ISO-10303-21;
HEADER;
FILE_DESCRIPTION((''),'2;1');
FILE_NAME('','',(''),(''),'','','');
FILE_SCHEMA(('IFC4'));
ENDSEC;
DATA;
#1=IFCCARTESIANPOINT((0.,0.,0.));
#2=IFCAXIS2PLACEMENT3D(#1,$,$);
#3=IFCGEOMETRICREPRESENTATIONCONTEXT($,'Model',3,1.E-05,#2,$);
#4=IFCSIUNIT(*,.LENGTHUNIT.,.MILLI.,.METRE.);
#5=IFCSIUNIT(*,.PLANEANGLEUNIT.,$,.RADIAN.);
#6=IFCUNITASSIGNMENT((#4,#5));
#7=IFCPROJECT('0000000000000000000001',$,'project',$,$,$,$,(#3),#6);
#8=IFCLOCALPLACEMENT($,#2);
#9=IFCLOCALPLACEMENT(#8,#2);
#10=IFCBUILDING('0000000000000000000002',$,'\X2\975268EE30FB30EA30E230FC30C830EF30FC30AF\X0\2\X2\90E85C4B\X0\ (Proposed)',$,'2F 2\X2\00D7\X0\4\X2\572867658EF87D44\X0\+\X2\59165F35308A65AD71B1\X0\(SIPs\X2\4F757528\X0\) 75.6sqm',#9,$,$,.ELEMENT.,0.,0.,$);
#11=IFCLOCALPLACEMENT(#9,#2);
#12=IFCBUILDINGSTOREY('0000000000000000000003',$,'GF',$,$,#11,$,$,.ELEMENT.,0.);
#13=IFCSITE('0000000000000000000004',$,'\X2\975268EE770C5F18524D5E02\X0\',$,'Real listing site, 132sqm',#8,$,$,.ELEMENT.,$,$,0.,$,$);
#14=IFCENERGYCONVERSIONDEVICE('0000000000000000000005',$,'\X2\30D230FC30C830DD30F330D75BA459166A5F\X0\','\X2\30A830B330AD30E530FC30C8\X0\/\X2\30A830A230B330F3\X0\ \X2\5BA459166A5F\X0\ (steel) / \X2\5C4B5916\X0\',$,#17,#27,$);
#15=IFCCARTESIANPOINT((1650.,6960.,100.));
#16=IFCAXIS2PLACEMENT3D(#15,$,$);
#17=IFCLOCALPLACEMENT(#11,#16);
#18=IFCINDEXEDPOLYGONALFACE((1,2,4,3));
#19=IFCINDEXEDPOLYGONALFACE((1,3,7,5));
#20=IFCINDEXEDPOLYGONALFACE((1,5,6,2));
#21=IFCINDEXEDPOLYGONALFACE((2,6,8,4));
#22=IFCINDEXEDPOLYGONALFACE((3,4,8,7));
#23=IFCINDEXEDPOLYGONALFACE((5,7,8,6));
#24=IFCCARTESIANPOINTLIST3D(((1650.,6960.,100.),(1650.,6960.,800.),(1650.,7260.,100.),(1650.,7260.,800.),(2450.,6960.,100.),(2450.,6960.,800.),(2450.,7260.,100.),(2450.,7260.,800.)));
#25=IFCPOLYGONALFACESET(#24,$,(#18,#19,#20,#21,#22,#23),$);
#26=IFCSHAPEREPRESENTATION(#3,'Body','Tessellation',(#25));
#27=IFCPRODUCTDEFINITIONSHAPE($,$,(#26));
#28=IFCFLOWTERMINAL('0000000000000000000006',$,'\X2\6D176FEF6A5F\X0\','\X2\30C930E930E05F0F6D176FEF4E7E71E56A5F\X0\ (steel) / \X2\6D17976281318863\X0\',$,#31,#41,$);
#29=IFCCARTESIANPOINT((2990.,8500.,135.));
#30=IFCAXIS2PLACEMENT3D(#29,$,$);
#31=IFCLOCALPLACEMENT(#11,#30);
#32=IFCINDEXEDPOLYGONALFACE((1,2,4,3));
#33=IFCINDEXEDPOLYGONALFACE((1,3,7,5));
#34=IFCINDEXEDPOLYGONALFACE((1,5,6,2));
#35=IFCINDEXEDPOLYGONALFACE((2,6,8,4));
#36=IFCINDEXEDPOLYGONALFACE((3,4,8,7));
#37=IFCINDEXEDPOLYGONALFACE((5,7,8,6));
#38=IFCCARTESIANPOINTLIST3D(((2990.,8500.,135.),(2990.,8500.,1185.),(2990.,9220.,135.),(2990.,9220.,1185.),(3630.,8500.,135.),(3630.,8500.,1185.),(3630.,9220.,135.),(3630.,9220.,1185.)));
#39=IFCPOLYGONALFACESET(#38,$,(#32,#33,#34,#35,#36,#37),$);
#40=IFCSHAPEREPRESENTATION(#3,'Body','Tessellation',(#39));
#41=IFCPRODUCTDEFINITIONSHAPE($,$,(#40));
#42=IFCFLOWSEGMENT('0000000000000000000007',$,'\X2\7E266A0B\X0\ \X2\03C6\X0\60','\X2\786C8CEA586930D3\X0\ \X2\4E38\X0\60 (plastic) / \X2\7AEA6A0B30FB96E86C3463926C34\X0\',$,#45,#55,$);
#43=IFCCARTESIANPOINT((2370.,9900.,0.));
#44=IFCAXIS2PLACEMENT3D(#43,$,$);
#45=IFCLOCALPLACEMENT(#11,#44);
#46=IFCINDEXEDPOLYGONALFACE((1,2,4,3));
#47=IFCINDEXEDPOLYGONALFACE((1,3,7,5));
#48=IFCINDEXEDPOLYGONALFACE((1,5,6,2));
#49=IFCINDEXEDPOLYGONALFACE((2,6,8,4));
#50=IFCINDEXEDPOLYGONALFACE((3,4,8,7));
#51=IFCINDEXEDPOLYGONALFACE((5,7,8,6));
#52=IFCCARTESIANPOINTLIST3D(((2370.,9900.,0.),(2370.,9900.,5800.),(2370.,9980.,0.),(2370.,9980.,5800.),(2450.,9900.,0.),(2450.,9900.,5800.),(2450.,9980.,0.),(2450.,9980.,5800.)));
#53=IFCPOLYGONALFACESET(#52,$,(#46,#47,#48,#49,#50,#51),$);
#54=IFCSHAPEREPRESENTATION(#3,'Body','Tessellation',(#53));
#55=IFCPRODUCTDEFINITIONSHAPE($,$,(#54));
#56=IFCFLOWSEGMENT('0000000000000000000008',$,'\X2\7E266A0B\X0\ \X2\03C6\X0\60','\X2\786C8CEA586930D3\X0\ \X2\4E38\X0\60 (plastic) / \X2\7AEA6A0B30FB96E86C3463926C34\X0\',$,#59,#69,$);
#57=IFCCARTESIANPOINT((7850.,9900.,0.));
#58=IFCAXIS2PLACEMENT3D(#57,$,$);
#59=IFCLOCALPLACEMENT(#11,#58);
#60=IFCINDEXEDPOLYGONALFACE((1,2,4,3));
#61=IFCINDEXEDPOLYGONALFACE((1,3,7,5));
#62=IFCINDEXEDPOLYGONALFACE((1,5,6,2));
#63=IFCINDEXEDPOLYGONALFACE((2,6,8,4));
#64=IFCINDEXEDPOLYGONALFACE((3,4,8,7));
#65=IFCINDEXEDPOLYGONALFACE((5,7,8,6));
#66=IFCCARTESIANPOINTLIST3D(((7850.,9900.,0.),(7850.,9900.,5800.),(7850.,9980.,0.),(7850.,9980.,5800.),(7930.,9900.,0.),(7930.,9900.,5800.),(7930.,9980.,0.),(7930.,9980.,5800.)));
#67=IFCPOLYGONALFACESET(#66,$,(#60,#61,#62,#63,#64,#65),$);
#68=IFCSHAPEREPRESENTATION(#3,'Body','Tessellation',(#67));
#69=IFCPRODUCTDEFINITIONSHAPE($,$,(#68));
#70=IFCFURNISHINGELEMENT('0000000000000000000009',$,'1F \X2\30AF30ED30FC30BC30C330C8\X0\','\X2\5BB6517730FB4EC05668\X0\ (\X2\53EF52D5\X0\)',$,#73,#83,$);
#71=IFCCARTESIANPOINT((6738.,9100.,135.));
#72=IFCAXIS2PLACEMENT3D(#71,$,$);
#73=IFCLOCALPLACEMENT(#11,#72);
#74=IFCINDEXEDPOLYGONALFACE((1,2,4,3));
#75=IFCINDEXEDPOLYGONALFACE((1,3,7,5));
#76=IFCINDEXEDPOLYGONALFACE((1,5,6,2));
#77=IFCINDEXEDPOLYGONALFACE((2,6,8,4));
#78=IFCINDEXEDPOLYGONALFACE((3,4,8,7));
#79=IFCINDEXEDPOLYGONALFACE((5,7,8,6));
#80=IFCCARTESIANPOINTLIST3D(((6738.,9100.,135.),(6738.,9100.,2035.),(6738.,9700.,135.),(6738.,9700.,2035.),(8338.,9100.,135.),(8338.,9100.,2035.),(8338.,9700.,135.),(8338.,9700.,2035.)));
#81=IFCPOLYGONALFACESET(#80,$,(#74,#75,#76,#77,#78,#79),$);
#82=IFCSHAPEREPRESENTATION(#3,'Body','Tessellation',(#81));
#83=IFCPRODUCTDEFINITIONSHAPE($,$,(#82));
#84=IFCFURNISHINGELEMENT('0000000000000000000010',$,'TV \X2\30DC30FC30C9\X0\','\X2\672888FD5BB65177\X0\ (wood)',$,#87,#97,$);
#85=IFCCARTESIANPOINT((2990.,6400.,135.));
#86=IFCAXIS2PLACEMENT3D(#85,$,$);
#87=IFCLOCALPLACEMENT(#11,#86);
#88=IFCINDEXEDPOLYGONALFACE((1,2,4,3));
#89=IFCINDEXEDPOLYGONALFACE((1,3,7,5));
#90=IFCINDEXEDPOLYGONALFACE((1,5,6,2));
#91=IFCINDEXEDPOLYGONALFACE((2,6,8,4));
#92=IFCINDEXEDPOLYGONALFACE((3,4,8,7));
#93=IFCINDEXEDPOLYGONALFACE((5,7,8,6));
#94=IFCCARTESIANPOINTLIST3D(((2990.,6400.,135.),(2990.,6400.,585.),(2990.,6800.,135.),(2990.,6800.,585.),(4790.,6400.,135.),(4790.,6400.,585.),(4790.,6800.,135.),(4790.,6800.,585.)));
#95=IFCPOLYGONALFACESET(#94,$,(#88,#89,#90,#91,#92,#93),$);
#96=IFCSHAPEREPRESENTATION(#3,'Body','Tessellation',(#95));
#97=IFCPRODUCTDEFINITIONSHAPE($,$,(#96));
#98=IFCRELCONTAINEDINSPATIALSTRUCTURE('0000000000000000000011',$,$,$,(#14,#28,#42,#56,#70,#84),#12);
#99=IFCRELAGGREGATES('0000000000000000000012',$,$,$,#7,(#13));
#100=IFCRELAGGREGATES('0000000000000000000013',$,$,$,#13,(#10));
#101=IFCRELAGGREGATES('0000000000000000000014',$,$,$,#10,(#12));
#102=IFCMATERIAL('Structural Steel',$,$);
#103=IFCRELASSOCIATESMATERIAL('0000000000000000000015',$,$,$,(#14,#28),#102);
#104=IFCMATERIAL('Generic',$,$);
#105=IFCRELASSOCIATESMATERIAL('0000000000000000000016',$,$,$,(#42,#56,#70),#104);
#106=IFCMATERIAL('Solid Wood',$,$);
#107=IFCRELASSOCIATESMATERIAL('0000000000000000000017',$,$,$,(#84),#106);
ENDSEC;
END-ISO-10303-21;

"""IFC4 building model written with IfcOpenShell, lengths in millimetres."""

from ifc_helpers import new_model, si_unit, frame, frame_2d, origin, place, context, project, spatial, rectangle, extrude, material, element, save


model = new_model("IFC4")

# Units and contexts
model_context = context("Model", 3, precision=1e-05, world=origin())
ifc_project = project(units=[si_unit("LENGTHUNIT", "METRE", prefix="MILLI"), si_unit("PLANEANGLEUNIT", "RADIAN")], contexts=[model_context])

# Site, building, storey
site_placement = place(None, origin())
site = spatial("IfcSite", under=ifc_project, at=site_placement, Name="青森県弘前市", ObjectType="Real listing site, 132sqm", CompositionType="ELEMENT", RefElevation=0.0)
building_placement = place(site_placement, origin())
building = spatial("IfcBuilding", under=site, at=building_placement, Name="青森・リモートワーク2部屋 (Proposed)", ObjectType="2F 2×4在来軸組+外張り断熱(SIPs併用) 75.6sqm", CompositionType="ELEMENT", ElevationOfRefHeight=0.0, ElevationOfTerrain=0.0)
storey_placement = place(building_placement, origin())
storey = spatial("IfcBuildingStorey", under=building, at=storey_placement, Name="GF", CompositionType="ELEMENT", Elevation=0.0)

# Shared definitions
ifc_material_1 = material(Name="Solid Wood")

# Shared definitions
ifc_material_2 = material(Name="Generic")

# Shared definitions
ifc_material_3 = material(Name="Structural Steel")

# Energy conversion device
energy_conversion_device_placement = place(storey_placement, frame((1650.0, 6960.0, 100.0)))
element("IfcEnergyConversionDevice", 1, at=energy_conversion_device_placement, inside=storey, material=ifc_material_3, Name="ヒートポンプ室外機", Description="エコキュート/エアコン 室外機 (steel) / 屋外", context=model_context, shape_type="SweptSolid", body=[
    extrude(rectangle(XDim=800.0, YDim=300.0, at=frame_2d((400.0, 150.0))), frame((1650.0, 6960.0, 100.0)), (0.0, 0.0, 1.0), 700.0),
])

# Flow terminal
flow_terminal_placement = place(storey_placement, frame((2990.0, 8500.0, 135.0)))
element("IfcFlowTerminal", 2, at=flow_terminal_placement, inside=storey, material=ifc_material_3, Name="洗濯機", Description="ドラム式洗濯乾燥機 (steel) / 洗面脱衣", context=model_context, shape_type="SweptSolid", body=[
    extrude(rectangle(XDim=640.0, YDim=720.0, at=frame_2d((320.0, 360.0))), frame((2990.0, 8500.0, 135.0)), (0.0, 0.0, 1.0), 1050.0),
])

# Flow segments
flow_segment_1_placement = place(storey_placement, frame((2370.0, 9900.0, 0.0)))
element("IfcFlowSegment", 3, at=flow_segment_1_placement, inside=storey, material=ifc_material_2, Name="縦樋 φ60", Description="硬質塩ビ 丸60 (plastic) / 竪樋・雨水排水", context=model_context, shape_type="SweptSolid", body=[
    extrude(rectangle(XDim=80.0, YDim=80.0, at=frame_2d((40.0, 40.0))), frame((2370.0, 9900.0, 0.0)), (0.0, 0.0, 1.0), 5800.0),
])
flow_segment_2_placement = place(storey_placement, frame((7850.0, 9900.0, 0.0)))
element("IfcFlowSegment", 4, at=flow_segment_2_placement, inside=storey, material=ifc_material_2, Name="縦樋 φ60", Description="硬質塩ビ 丸60 (plastic) / 竪樋・雨水排水", context=model_context, shape_type="SweptSolid", body=[
    extrude(rectangle(XDim=80.0, YDim=80.0, at=frame_2d((40.0, 40.0))), frame((7850.0, 9900.0, 0.0)), (0.0, 0.0, 1.0), 5800.0),
])

# Furnishing elements
furnishing_1_placement = place(storey_placement, frame((6738.0, 9100.0, 135.0)))
element("IfcFurnishingElement", 5, at=furnishing_1_placement, inside=storey, material=ifc_material_2, Name="1F クローゼット", Description="家具・什器 (可動)", context=model_context, shape_type="SweptSolid", body=[
    extrude(rectangle(XDim=1600.0, YDim=600.0, at=frame_2d((800.0, 300.0))), frame((6738.0, 9100.0, 135.0)), (0.0, 0.0, 1.0), 1900.0),
])
furnishing_2_placement = place(storey_placement, frame((2990.0, 6400.0, 135.0)))
element("IfcFurnishingElement", 6, at=furnishing_2_placement, inside=storey, material=ifc_material_1, Name="TV ボード", Description="木製家具 (wood)", context=model_context, shape_type="SweptSolid", body=[
    extrude(rectangle(XDim=1800.0, YDim=400.0, at=frame_2d((900.0, 200.0))), frame((2990.0, 6400.0, 135.0)), (0.0, 0.0, 1.0), 450.0),
])

save(model, "model.ifc")
